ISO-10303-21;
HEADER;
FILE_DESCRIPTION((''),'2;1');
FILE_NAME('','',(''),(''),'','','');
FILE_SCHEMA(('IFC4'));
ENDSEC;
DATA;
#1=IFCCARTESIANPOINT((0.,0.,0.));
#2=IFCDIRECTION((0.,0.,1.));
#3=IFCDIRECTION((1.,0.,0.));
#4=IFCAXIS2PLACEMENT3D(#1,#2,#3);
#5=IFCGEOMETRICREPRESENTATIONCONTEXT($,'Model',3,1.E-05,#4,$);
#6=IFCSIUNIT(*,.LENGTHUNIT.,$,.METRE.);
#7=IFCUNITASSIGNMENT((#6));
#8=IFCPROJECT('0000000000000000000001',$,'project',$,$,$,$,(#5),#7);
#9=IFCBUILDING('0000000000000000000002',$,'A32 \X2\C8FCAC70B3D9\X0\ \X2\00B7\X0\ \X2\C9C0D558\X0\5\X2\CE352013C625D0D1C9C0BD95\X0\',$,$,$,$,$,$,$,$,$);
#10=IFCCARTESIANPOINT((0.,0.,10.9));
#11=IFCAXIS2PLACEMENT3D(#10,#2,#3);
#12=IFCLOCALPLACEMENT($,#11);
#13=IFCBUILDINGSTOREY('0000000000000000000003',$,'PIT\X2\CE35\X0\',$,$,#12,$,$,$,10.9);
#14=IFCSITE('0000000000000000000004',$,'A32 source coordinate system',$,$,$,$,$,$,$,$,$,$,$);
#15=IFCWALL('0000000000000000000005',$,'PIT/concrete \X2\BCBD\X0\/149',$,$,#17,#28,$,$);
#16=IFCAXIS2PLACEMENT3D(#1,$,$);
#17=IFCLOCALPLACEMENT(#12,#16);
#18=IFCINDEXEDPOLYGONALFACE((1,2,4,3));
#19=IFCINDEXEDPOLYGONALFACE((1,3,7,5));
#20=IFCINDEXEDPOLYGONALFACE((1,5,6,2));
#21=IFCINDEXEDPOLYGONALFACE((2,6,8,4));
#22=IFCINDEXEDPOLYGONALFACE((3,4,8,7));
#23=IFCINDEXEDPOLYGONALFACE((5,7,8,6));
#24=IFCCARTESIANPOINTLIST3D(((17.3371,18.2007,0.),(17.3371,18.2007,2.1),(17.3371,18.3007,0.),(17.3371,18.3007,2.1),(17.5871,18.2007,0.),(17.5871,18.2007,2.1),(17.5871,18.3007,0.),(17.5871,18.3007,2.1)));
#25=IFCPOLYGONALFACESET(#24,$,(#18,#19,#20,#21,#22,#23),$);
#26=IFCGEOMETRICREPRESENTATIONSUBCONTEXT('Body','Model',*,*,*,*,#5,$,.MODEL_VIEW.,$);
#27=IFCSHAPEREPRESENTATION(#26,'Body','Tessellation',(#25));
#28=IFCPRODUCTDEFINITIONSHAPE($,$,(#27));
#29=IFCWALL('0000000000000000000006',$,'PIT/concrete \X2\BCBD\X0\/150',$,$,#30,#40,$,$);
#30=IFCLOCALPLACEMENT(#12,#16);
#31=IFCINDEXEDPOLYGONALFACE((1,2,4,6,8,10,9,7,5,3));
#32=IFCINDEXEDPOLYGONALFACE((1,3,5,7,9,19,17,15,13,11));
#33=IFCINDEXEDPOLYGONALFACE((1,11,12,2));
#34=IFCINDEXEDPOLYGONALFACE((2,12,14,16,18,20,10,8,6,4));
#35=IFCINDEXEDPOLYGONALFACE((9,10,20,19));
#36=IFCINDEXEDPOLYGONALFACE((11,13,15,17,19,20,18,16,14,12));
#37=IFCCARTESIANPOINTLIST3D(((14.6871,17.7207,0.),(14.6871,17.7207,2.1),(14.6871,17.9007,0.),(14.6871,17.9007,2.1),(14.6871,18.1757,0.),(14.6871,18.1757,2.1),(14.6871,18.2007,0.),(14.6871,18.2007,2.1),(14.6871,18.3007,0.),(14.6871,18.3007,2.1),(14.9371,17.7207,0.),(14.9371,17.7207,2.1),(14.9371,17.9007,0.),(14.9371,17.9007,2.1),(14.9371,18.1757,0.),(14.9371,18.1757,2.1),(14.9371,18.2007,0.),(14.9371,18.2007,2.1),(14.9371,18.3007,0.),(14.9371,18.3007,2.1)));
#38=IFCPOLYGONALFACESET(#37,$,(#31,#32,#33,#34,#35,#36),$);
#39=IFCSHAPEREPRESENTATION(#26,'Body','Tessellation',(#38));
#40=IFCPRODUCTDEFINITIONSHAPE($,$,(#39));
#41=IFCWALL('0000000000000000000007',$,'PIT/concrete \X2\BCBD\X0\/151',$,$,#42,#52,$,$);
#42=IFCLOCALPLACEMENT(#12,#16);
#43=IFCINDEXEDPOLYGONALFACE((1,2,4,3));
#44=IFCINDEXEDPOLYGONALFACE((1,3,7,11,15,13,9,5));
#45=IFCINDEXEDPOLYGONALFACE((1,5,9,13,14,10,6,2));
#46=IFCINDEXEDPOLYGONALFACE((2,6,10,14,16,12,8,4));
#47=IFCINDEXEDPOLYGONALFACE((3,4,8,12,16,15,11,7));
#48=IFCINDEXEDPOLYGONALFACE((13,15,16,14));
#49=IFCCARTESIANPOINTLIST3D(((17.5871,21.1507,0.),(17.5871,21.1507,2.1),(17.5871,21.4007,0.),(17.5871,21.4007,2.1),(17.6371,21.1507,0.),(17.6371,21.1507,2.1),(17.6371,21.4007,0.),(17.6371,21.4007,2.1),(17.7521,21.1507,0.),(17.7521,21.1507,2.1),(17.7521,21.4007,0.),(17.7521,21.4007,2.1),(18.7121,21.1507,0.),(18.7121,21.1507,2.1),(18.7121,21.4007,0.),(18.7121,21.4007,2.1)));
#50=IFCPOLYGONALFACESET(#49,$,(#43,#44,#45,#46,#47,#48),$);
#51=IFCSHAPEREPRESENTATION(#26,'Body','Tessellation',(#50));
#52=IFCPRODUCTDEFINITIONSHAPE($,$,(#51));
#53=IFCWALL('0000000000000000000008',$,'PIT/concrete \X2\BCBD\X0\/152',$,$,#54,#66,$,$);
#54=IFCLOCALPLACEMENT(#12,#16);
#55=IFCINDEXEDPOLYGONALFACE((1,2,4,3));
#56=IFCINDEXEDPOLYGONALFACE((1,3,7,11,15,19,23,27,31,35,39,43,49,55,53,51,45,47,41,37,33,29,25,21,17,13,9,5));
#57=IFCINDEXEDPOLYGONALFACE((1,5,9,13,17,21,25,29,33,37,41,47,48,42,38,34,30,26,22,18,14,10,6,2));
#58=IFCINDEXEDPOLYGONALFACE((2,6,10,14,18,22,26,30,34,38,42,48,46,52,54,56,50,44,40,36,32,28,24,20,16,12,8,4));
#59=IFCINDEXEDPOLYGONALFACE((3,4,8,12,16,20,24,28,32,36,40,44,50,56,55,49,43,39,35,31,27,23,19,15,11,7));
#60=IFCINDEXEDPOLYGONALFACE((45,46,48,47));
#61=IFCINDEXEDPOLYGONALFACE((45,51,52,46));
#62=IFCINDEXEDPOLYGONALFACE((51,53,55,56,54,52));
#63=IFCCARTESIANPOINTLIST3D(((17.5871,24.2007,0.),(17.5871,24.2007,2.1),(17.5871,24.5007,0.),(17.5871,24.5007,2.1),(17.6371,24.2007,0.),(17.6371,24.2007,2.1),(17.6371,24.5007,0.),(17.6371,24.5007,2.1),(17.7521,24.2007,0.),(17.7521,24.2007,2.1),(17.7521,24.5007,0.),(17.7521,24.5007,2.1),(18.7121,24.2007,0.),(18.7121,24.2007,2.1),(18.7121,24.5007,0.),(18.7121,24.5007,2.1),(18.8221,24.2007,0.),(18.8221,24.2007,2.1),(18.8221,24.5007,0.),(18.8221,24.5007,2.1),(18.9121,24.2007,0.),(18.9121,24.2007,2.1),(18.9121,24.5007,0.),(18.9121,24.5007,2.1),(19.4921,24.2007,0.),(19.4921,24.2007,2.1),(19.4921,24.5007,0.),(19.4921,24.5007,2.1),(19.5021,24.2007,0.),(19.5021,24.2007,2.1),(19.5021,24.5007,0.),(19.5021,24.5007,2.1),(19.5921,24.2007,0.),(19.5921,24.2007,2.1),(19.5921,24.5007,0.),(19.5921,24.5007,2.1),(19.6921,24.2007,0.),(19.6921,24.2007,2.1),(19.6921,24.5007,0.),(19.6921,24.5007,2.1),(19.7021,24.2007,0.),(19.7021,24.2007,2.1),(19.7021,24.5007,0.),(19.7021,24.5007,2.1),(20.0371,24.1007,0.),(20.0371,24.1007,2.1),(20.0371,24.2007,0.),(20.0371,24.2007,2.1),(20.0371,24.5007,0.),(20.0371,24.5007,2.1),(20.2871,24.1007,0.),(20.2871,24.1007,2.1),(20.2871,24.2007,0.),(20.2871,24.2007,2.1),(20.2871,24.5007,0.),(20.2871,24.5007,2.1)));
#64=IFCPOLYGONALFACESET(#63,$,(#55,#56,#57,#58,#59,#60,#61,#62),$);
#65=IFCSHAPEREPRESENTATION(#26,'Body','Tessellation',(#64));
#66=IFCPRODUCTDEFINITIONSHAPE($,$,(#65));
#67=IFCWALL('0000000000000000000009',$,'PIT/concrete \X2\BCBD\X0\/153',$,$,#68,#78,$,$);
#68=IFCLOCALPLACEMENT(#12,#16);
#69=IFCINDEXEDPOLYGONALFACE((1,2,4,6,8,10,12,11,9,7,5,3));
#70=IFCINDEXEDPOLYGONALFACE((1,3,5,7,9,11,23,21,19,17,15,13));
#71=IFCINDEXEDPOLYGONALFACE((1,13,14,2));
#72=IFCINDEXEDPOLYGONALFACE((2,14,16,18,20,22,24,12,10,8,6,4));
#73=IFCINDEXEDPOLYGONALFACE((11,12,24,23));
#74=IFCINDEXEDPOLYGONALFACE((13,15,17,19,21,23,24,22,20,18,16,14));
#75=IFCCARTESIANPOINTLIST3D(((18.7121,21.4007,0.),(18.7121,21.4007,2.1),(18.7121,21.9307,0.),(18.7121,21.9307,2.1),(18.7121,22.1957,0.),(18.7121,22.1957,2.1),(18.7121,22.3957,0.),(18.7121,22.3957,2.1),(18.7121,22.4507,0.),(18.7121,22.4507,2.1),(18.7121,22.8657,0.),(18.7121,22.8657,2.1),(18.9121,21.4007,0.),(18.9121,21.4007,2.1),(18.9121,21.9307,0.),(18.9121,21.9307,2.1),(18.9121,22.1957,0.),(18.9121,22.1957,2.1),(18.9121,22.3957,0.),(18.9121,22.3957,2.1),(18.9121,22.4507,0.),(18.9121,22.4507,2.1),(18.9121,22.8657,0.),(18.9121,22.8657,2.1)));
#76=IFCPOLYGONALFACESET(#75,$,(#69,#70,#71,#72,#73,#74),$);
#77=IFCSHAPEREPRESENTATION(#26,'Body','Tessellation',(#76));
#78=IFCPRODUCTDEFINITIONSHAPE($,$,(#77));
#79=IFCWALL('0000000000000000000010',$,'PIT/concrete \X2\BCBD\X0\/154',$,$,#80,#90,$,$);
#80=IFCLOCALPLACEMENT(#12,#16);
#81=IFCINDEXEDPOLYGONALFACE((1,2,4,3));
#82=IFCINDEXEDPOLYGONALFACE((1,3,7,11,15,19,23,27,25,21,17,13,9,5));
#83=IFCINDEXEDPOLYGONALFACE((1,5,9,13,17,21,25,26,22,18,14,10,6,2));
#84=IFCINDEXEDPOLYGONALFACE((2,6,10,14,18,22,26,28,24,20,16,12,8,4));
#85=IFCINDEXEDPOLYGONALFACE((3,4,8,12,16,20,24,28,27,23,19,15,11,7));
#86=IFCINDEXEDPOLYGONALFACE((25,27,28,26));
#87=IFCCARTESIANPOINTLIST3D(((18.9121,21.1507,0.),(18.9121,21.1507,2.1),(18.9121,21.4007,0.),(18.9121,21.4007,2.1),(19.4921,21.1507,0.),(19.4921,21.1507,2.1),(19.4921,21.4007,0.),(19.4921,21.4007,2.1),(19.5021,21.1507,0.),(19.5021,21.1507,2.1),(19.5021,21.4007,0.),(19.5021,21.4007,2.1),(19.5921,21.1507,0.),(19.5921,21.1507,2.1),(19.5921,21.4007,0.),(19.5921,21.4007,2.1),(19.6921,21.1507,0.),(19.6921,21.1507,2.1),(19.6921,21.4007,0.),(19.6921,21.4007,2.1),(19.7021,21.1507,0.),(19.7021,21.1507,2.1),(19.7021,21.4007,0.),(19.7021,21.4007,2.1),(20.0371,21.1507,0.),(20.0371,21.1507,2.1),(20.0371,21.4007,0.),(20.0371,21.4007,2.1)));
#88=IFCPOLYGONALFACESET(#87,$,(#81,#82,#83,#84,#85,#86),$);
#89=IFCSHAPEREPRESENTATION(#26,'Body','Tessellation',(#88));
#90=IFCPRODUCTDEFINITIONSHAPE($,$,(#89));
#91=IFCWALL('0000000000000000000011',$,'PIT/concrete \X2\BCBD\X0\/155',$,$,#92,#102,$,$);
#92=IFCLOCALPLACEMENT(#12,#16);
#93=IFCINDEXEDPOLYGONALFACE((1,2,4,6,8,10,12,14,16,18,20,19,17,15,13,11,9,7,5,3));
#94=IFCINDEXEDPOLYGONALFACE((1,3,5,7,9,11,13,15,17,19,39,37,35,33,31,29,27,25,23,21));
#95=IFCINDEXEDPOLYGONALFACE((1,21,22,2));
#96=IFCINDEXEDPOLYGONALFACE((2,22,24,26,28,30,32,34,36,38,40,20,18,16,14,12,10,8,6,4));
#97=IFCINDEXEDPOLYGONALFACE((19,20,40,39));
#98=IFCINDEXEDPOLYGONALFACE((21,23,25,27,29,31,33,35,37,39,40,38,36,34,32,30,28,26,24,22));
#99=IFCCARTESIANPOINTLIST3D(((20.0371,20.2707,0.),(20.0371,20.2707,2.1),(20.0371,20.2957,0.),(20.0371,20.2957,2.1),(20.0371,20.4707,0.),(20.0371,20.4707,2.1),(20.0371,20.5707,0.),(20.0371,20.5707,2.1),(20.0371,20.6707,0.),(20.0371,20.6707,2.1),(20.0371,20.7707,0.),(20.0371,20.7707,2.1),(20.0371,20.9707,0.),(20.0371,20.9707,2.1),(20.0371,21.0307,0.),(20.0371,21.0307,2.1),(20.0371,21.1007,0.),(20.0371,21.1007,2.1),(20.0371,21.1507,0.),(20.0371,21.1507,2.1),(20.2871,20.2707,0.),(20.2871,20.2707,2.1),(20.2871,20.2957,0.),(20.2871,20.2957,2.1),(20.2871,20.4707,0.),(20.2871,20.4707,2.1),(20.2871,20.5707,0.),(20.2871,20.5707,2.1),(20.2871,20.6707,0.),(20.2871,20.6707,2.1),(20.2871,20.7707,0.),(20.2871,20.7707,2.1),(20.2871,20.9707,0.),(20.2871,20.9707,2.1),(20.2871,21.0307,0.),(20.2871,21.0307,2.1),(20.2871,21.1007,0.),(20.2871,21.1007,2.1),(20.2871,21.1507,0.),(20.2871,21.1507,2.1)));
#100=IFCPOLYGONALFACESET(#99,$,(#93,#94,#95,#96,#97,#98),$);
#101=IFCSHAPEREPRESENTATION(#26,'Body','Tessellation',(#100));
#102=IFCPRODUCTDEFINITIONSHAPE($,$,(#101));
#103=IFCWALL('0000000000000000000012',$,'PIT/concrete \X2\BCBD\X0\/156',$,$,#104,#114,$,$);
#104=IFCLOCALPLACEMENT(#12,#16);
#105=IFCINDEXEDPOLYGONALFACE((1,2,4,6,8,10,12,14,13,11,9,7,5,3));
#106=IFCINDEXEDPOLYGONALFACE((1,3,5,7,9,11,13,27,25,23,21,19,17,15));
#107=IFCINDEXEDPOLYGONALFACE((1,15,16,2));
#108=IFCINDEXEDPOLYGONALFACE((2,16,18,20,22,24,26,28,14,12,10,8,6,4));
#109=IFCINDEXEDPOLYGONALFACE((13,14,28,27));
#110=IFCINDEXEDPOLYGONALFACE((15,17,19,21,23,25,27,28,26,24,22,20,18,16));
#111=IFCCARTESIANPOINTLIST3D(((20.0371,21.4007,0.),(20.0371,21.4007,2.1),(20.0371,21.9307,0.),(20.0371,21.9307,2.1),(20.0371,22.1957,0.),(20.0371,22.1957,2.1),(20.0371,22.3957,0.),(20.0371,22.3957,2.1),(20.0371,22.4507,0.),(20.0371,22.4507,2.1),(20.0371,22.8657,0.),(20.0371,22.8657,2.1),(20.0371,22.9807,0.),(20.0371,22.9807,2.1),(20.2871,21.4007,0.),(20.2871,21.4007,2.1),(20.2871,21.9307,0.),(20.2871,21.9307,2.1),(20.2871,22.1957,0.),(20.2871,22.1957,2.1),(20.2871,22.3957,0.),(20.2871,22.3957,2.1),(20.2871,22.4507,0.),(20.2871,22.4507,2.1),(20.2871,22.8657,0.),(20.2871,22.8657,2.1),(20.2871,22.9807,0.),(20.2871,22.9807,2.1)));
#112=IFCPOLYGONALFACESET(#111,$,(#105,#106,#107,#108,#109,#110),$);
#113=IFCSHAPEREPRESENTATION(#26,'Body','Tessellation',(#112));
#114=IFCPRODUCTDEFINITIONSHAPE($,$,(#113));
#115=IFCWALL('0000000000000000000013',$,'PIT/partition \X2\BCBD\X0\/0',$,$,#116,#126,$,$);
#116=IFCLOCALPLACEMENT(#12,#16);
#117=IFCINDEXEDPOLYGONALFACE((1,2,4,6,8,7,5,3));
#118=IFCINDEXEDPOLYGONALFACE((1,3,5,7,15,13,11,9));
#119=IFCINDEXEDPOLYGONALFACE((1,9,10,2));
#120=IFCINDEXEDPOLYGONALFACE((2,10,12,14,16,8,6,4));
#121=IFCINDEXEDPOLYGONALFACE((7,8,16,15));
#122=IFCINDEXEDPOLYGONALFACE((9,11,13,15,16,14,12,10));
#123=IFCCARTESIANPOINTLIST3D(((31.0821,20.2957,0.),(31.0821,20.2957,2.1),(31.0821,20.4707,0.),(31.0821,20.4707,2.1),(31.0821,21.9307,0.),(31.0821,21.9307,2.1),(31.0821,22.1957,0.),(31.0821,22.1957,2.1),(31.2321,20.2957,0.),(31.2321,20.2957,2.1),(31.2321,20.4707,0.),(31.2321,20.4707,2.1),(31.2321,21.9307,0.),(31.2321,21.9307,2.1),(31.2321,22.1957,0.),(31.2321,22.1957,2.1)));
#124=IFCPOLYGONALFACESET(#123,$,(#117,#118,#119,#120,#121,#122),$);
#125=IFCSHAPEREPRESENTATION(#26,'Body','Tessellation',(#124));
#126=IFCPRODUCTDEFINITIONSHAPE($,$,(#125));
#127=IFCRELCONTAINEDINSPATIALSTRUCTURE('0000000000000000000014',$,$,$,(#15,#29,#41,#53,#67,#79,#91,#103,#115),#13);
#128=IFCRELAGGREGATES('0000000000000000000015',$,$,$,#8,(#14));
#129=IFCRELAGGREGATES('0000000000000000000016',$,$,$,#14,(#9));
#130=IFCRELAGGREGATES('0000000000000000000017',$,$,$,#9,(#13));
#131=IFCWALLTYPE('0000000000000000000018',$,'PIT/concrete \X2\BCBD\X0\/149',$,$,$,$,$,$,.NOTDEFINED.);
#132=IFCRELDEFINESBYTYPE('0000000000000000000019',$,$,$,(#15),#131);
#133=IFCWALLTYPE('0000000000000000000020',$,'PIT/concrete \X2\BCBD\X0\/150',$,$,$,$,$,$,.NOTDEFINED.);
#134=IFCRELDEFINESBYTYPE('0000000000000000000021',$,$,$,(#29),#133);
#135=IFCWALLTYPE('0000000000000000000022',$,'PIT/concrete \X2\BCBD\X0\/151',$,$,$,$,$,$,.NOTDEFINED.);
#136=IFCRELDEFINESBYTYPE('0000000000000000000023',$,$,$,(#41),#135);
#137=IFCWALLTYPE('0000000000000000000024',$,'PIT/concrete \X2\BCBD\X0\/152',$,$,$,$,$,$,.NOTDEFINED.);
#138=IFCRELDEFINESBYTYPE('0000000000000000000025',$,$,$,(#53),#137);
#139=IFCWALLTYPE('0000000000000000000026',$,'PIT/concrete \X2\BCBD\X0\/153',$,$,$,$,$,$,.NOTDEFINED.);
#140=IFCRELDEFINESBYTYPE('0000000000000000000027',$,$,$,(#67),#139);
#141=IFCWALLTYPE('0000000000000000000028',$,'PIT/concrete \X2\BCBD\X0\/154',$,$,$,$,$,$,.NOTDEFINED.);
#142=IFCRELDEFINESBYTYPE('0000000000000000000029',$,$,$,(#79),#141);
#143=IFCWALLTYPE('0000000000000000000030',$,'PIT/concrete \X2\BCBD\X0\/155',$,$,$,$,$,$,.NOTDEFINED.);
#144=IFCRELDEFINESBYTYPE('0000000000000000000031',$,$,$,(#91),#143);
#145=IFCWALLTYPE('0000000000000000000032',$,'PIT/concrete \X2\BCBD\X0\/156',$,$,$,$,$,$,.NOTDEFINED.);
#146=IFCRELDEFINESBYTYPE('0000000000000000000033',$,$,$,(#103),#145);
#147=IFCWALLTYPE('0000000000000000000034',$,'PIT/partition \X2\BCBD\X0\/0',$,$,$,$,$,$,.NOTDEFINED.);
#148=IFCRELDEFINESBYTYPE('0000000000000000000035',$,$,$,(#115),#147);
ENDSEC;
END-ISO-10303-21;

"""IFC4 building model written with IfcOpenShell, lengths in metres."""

from ifc_helpers import new_model, si_unit, frame, origin, origin_with_axes, place, context, subcontext, project, spatial, polyline, outline, extrude, source, transform, mapped, type_object, type_shapes, element, save


model = new_model("IFC4")

# Units and contexts
model_context = context("Model", 3, precision=1e-05, world=origin_with_axes())
body_context = subcontext(model_context, "Body", "Model", "MODEL_VIEW")
ifc_project = project(units=[si_unit("LENGTHUNIT", "METRE")], contexts=[model_context])

# Site, building, storey
site = spatial("IfcSite", under=ifc_project, Name="A32 source coordinate system")
building = spatial("IfcBuilding", under=site, Name="A32 주거동 · 지하5층–옥탑지붕")
storey_placement = place(None, frame((0.0, 0.0, 10.9), z_axis=(0.0, 0.0, 1.0), x_axis=(1.0, 0.0, 0.0)))
storey = spatial("IfcBuildingStorey", under=building, at=storey_placement, Name="PIT층", Elevation=10.9)

# Walls
wall_type_1 = type_object("IfcWallType", Name="PIT/concrete 벽/149", PredefinedType="NOTDEFINED")
shared_shape_1 = source(origin(), body_context, "Body", "SweptSolid", [
    extrude(outline(polyline([(17.3371, 18.2007), (17.3371, 18.3007), (17.5871, 18.3007), (17.5871, 18.2007), (17.3371, 18.2007)])), origin(), (0.0, 0.0, 1.0), 2.1),
])
type_shapes(wall_type_1, [shared_shape_1])
wall_1_placement = place(storey_placement, origin_with_axes())
element("IfcWall", 1, at=wall_1_placement, inside=storey, type_object=wall_type_1, Name="PIT/concrete 벽/149", context=body_context, shape_type="MappedRepresentation", body=[
    mapped(shared_shape_1, transform((0.0, 0.0, 0.0), scale=1.0)),
])
wall_type_2 = type_object("IfcWallType", Name="PIT/concrete 벽/150", PredefinedType="NOTDEFINED")
shared_shape_2 = source(origin(), body_context, "Body", "SweptSolid", [
    extrude(outline(polyline([(14.9371, 17.9007), (14.9371, 17.7207), (14.6871, 17.7207), (14.6871, 17.9007), (14.6871, 18.1757), (14.6871, 18.2007), (14.6871, 18.3007), (14.9371, 18.3007), (14.9371, 18.2007), (14.9371, 18.1757), (14.9371, 17.9007)])), origin(), (0.0, 0.0, 1.0), 2.1),
])
type_shapes(wall_type_2, [shared_shape_2])
wall_2_placement = place(storey_placement, origin_with_axes())
element("IfcWall", 2, at=wall_2_placement, inside=storey, type_object=wall_type_2, Name="PIT/concrete 벽/150", context=body_context, shape_type="MappedRepresentation", body=[
    mapped(shared_shape_2, transform((0.0, 0.0, 0.0), scale=1.0)),
])
wall_type_3 = type_object("IfcWallType", Name="PIT/concrete 벽/151", PredefinedType="NOTDEFINED")
shared_shape_3 = source(origin(), body_context, "Body", "SweptSolid", [
    extrude(outline(polyline([(17.7521, 21.4007), (18.7121, 21.4007), (18.7121, 21.1507), (17.7521, 21.1507), (17.6371, 21.1507), (17.5871, 21.1507), (17.5871, 21.4007), (17.6371, 21.4007), (17.7521, 21.4007)])), origin(), (0.0, 0.0, 1.0), 2.1),
])
type_shapes(wall_type_3, [shared_shape_3])
wall_3_placement = place(storey_placement, origin_with_axes())
element("IfcWall", 3, at=wall_3_placement, inside=storey, type_object=wall_type_3, Name="PIT/concrete 벽/151", context=body_context, shape_type="MappedRepresentation", body=[
    mapped(shared_shape_3, transform((0.0, 0.0, 0.0), scale=1.0)),
])
wall_type_4 = type_object("IfcWallType", Name="PIT/concrete 벽/152", PredefinedType="NOTDEFINED")
shared_shape_4 = source(origin(), body_context, "Body", "SweptSolid", [
    extrude(outline(polyline([(17.7521, 24.5007), (18.7121, 24.5007), (18.8221, 24.5007), (18.9121, 24.5007), (19.4921, 24.5007), (19.5021, 24.5007), (19.5921, 24.5007), (19.6921, 24.5007), (19.7021, 24.5007), (20.0371, 24.5007), (20.2871, 24.5007), (20.2871, 24.2007), (20.2871, 24.1007), (20.0371, 24.1007), (20.0371, 24.2007), (19.7021, 24.2007), (19.6921, 24.2007), (19.5921, 24.2007), (19.5021, 24.2007), (19.4921, 24.2007), (18.9121, 24.2007), (18.8221, 24.2007), (18.7121, 24.2007), (17.7521, 24.2007), (17.6371, 24.2007), (17.5871, 24.2007), (17.5871, 24.5007), (17.6371, 24.5007), (17.7521, 24.5007)])), origin(), (0.0, 0.0, 1.0), 2.1),
])
type_shapes(wall_type_4, [shared_shape_4])
wall_4_placement = place(storey_placement, origin_with_axes())
element("IfcWall", 4, at=wall_4_placement, inside=storey, type_object=wall_type_4, Name="PIT/concrete 벽/152", context=body_context, shape_type="MappedRepresentation", body=[
    mapped(shared_shape_4, transform((0.0, 0.0, 0.0), scale=1.0)),
])
wall_type_5 = type_object("IfcWallType", Name="PIT/concrete 벽/153", PredefinedType="NOTDEFINED")
shared_shape_5 = source(origin(), body_context, "Body", "SweptSolid", [
    extrude(outline(polyline([(18.7121, 22.3957), (18.7121, 22.4507), (18.7121, 22.8657), (18.9121, 22.8657), (18.9121, 22.4507), (18.9121, 22.3957), (18.9121, 22.1957), (18.9121, 21.9307), (18.9121, 21.4007), (18.7121, 21.4007), (18.7121, 21.9307), (18.7121, 22.1957), (18.7121, 22.3957)])), origin(), (0.0, 0.0, 1.0), 2.1),
])
type_shapes(wall_type_5, [shared_shape_5])
wall_5_placement = place(storey_placement, origin_with_axes())
element("IfcWall", 5, at=wall_5_placement, inside=storey, type_object=wall_type_5, Name="PIT/concrete 벽/153", context=body_context, shape_type="MappedRepresentation", body=[
    mapped(shared_shape_5, transform((0.0, 0.0, 0.0), scale=1.0)),
])
wall_type_6 = type_object("IfcWallType", Name="PIT/concrete 벽/154", PredefinedType="NOTDEFINED")
shared_shape_6 = source(origin(), body_context, "Body", "SweptSolid", [
    extrude(outline(polyline([(19.5921, 21.4007), (19.6921, 21.4007), (19.7021, 21.4007), (20.0371, 21.4007), (20.0371, 21.1507), (19.7021, 21.1507), (19.6921, 21.1507), (19.5921, 21.1507), (19.5021, 21.1507), (19.4921, 21.1507), (18.9121, 21.1507), (18.9121, 21.4007), (19.4921, 21.4007), (19.5021, 21.4007), (19.5921, 21.4007)])), origin(), (0.0, 0.0, 1.0), 2.1),
])
type_shapes(wall_type_6, [shared_shape_6])
wall_6_placement = place(storey_placement, origin_with_axes())
element("IfcWall", 6, at=wall_6_placement, inside=storey, type_object=wall_type_6, Name="PIT/concrete 벽/154", context=body_context, shape_type="MappedRepresentation", body=[
    mapped(shared_shape_6, transform((0.0, 0.0, 0.0), scale=1.0)),
])
wall_type_7 = type_object("IfcWallType", Name="PIT/concrete 벽/155", PredefinedType="NOTDEFINED")
shared_shape_7 = source(origin(), body_context, "Body", "SweptSolid", [
    extrude(outline(polyline([(20.2871, 21.0307), (20.2871, 20.9707), (20.2871, 20.7707), (20.2871, 20.6707), (20.2871, 20.5707), (20.2871, 20.4707), (20.2871, 20.2957), (20.2871, 20.2707), (20.0371, 20.2707), (20.0371, 20.2957), (20.0371, 20.4707), (20.0371, 20.5707), (20.0371, 20.6707), (20.0371, 20.7707), (20.0371, 20.9707), (20.0371, 21.0307), (20.0371, 21.1007), (20.0371, 21.1507), (20.2871, 21.1507), (20.2871, 21.1007), (20.2871, 21.0307)])), origin(), (0.0, 0.0, 1.0), 2.1),
])
type_shapes(wall_type_7, [shared_shape_7])
wall_7_placement = place(storey_placement, origin_with_axes())
element("IfcWall", 7, at=wall_7_placement, inside=storey, type_object=wall_type_7, Name="PIT/concrete 벽/155", context=body_context, shape_type="MappedRepresentation", body=[
    mapped(shared_shape_7, transform((0.0, 0.0, 0.0), scale=1.0)),
])
wall_type_8 = type_object("IfcWallType", Name="PIT/concrete 벽/156", PredefinedType="NOTDEFINED")
shared_shape_8 = source(origin(), body_context, "Body", "SweptSolid", [
    extrude(outline(polyline([(20.0371, 22.3957), (20.0371, 22.4507), (20.0371, 22.8657), (20.0371, 22.9807), (20.2871, 22.9807), (20.2871, 22.8657), (20.2871, 22.4507), (20.2871, 22.3957), (20.2871, 22.1957), (20.2871, 21.9307), (20.2871, 21.4007), (20.0371, 21.4007), (20.0371, 21.9307), (20.0371, 22.1957), (20.0371, 22.3957)])), origin(), (0.0, 0.0, 1.0), 2.1),
])
type_shapes(wall_type_8, [shared_shape_8])
wall_8_placement = place(storey_placement, origin_with_axes())
element("IfcWall", 8, at=wall_8_placement, inside=storey, type_object=wall_type_8, Name="PIT/concrete 벽/156", context=body_context, shape_type="MappedRepresentation", body=[
    mapped(shared_shape_8, transform((0.0, 0.0, 0.0), scale=1.0)),
])
wall_type_9 = type_object("IfcWallType", Name="PIT/partition 벽/0", PredefinedType="NOTDEFINED")
shared_shape_9 = source(origin(), body_context, "Body", "SweptSolid", [
    extrude(outline(polyline([(31.2321, 22.1957), (31.2321, 21.9307), (31.2321, 20.4707), (31.2321, 20.2957), (31.0821, 20.2957), (31.0821, 20.4707), (31.0821, 21.9307), (31.0821, 22.1957), (31.2321, 22.1957)])), origin(), (0.0, 0.0, 1.0), 2.1),
])
type_shapes(wall_type_9, [shared_shape_9])
wall_9_placement = place(storey_placement, origin_with_axes())
element("IfcWall", 9, at=wall_9_placement, inside=storey, type_object=wall_type_9, Name="PIT/partition 벽/0", context=body_context, shape_type="MappedRepresentation", body=[
    mapped(shared_shape_9, transform((0.0, 0.0, 0.0), scale=1.0)),
])

save(model, "model.ifc")
